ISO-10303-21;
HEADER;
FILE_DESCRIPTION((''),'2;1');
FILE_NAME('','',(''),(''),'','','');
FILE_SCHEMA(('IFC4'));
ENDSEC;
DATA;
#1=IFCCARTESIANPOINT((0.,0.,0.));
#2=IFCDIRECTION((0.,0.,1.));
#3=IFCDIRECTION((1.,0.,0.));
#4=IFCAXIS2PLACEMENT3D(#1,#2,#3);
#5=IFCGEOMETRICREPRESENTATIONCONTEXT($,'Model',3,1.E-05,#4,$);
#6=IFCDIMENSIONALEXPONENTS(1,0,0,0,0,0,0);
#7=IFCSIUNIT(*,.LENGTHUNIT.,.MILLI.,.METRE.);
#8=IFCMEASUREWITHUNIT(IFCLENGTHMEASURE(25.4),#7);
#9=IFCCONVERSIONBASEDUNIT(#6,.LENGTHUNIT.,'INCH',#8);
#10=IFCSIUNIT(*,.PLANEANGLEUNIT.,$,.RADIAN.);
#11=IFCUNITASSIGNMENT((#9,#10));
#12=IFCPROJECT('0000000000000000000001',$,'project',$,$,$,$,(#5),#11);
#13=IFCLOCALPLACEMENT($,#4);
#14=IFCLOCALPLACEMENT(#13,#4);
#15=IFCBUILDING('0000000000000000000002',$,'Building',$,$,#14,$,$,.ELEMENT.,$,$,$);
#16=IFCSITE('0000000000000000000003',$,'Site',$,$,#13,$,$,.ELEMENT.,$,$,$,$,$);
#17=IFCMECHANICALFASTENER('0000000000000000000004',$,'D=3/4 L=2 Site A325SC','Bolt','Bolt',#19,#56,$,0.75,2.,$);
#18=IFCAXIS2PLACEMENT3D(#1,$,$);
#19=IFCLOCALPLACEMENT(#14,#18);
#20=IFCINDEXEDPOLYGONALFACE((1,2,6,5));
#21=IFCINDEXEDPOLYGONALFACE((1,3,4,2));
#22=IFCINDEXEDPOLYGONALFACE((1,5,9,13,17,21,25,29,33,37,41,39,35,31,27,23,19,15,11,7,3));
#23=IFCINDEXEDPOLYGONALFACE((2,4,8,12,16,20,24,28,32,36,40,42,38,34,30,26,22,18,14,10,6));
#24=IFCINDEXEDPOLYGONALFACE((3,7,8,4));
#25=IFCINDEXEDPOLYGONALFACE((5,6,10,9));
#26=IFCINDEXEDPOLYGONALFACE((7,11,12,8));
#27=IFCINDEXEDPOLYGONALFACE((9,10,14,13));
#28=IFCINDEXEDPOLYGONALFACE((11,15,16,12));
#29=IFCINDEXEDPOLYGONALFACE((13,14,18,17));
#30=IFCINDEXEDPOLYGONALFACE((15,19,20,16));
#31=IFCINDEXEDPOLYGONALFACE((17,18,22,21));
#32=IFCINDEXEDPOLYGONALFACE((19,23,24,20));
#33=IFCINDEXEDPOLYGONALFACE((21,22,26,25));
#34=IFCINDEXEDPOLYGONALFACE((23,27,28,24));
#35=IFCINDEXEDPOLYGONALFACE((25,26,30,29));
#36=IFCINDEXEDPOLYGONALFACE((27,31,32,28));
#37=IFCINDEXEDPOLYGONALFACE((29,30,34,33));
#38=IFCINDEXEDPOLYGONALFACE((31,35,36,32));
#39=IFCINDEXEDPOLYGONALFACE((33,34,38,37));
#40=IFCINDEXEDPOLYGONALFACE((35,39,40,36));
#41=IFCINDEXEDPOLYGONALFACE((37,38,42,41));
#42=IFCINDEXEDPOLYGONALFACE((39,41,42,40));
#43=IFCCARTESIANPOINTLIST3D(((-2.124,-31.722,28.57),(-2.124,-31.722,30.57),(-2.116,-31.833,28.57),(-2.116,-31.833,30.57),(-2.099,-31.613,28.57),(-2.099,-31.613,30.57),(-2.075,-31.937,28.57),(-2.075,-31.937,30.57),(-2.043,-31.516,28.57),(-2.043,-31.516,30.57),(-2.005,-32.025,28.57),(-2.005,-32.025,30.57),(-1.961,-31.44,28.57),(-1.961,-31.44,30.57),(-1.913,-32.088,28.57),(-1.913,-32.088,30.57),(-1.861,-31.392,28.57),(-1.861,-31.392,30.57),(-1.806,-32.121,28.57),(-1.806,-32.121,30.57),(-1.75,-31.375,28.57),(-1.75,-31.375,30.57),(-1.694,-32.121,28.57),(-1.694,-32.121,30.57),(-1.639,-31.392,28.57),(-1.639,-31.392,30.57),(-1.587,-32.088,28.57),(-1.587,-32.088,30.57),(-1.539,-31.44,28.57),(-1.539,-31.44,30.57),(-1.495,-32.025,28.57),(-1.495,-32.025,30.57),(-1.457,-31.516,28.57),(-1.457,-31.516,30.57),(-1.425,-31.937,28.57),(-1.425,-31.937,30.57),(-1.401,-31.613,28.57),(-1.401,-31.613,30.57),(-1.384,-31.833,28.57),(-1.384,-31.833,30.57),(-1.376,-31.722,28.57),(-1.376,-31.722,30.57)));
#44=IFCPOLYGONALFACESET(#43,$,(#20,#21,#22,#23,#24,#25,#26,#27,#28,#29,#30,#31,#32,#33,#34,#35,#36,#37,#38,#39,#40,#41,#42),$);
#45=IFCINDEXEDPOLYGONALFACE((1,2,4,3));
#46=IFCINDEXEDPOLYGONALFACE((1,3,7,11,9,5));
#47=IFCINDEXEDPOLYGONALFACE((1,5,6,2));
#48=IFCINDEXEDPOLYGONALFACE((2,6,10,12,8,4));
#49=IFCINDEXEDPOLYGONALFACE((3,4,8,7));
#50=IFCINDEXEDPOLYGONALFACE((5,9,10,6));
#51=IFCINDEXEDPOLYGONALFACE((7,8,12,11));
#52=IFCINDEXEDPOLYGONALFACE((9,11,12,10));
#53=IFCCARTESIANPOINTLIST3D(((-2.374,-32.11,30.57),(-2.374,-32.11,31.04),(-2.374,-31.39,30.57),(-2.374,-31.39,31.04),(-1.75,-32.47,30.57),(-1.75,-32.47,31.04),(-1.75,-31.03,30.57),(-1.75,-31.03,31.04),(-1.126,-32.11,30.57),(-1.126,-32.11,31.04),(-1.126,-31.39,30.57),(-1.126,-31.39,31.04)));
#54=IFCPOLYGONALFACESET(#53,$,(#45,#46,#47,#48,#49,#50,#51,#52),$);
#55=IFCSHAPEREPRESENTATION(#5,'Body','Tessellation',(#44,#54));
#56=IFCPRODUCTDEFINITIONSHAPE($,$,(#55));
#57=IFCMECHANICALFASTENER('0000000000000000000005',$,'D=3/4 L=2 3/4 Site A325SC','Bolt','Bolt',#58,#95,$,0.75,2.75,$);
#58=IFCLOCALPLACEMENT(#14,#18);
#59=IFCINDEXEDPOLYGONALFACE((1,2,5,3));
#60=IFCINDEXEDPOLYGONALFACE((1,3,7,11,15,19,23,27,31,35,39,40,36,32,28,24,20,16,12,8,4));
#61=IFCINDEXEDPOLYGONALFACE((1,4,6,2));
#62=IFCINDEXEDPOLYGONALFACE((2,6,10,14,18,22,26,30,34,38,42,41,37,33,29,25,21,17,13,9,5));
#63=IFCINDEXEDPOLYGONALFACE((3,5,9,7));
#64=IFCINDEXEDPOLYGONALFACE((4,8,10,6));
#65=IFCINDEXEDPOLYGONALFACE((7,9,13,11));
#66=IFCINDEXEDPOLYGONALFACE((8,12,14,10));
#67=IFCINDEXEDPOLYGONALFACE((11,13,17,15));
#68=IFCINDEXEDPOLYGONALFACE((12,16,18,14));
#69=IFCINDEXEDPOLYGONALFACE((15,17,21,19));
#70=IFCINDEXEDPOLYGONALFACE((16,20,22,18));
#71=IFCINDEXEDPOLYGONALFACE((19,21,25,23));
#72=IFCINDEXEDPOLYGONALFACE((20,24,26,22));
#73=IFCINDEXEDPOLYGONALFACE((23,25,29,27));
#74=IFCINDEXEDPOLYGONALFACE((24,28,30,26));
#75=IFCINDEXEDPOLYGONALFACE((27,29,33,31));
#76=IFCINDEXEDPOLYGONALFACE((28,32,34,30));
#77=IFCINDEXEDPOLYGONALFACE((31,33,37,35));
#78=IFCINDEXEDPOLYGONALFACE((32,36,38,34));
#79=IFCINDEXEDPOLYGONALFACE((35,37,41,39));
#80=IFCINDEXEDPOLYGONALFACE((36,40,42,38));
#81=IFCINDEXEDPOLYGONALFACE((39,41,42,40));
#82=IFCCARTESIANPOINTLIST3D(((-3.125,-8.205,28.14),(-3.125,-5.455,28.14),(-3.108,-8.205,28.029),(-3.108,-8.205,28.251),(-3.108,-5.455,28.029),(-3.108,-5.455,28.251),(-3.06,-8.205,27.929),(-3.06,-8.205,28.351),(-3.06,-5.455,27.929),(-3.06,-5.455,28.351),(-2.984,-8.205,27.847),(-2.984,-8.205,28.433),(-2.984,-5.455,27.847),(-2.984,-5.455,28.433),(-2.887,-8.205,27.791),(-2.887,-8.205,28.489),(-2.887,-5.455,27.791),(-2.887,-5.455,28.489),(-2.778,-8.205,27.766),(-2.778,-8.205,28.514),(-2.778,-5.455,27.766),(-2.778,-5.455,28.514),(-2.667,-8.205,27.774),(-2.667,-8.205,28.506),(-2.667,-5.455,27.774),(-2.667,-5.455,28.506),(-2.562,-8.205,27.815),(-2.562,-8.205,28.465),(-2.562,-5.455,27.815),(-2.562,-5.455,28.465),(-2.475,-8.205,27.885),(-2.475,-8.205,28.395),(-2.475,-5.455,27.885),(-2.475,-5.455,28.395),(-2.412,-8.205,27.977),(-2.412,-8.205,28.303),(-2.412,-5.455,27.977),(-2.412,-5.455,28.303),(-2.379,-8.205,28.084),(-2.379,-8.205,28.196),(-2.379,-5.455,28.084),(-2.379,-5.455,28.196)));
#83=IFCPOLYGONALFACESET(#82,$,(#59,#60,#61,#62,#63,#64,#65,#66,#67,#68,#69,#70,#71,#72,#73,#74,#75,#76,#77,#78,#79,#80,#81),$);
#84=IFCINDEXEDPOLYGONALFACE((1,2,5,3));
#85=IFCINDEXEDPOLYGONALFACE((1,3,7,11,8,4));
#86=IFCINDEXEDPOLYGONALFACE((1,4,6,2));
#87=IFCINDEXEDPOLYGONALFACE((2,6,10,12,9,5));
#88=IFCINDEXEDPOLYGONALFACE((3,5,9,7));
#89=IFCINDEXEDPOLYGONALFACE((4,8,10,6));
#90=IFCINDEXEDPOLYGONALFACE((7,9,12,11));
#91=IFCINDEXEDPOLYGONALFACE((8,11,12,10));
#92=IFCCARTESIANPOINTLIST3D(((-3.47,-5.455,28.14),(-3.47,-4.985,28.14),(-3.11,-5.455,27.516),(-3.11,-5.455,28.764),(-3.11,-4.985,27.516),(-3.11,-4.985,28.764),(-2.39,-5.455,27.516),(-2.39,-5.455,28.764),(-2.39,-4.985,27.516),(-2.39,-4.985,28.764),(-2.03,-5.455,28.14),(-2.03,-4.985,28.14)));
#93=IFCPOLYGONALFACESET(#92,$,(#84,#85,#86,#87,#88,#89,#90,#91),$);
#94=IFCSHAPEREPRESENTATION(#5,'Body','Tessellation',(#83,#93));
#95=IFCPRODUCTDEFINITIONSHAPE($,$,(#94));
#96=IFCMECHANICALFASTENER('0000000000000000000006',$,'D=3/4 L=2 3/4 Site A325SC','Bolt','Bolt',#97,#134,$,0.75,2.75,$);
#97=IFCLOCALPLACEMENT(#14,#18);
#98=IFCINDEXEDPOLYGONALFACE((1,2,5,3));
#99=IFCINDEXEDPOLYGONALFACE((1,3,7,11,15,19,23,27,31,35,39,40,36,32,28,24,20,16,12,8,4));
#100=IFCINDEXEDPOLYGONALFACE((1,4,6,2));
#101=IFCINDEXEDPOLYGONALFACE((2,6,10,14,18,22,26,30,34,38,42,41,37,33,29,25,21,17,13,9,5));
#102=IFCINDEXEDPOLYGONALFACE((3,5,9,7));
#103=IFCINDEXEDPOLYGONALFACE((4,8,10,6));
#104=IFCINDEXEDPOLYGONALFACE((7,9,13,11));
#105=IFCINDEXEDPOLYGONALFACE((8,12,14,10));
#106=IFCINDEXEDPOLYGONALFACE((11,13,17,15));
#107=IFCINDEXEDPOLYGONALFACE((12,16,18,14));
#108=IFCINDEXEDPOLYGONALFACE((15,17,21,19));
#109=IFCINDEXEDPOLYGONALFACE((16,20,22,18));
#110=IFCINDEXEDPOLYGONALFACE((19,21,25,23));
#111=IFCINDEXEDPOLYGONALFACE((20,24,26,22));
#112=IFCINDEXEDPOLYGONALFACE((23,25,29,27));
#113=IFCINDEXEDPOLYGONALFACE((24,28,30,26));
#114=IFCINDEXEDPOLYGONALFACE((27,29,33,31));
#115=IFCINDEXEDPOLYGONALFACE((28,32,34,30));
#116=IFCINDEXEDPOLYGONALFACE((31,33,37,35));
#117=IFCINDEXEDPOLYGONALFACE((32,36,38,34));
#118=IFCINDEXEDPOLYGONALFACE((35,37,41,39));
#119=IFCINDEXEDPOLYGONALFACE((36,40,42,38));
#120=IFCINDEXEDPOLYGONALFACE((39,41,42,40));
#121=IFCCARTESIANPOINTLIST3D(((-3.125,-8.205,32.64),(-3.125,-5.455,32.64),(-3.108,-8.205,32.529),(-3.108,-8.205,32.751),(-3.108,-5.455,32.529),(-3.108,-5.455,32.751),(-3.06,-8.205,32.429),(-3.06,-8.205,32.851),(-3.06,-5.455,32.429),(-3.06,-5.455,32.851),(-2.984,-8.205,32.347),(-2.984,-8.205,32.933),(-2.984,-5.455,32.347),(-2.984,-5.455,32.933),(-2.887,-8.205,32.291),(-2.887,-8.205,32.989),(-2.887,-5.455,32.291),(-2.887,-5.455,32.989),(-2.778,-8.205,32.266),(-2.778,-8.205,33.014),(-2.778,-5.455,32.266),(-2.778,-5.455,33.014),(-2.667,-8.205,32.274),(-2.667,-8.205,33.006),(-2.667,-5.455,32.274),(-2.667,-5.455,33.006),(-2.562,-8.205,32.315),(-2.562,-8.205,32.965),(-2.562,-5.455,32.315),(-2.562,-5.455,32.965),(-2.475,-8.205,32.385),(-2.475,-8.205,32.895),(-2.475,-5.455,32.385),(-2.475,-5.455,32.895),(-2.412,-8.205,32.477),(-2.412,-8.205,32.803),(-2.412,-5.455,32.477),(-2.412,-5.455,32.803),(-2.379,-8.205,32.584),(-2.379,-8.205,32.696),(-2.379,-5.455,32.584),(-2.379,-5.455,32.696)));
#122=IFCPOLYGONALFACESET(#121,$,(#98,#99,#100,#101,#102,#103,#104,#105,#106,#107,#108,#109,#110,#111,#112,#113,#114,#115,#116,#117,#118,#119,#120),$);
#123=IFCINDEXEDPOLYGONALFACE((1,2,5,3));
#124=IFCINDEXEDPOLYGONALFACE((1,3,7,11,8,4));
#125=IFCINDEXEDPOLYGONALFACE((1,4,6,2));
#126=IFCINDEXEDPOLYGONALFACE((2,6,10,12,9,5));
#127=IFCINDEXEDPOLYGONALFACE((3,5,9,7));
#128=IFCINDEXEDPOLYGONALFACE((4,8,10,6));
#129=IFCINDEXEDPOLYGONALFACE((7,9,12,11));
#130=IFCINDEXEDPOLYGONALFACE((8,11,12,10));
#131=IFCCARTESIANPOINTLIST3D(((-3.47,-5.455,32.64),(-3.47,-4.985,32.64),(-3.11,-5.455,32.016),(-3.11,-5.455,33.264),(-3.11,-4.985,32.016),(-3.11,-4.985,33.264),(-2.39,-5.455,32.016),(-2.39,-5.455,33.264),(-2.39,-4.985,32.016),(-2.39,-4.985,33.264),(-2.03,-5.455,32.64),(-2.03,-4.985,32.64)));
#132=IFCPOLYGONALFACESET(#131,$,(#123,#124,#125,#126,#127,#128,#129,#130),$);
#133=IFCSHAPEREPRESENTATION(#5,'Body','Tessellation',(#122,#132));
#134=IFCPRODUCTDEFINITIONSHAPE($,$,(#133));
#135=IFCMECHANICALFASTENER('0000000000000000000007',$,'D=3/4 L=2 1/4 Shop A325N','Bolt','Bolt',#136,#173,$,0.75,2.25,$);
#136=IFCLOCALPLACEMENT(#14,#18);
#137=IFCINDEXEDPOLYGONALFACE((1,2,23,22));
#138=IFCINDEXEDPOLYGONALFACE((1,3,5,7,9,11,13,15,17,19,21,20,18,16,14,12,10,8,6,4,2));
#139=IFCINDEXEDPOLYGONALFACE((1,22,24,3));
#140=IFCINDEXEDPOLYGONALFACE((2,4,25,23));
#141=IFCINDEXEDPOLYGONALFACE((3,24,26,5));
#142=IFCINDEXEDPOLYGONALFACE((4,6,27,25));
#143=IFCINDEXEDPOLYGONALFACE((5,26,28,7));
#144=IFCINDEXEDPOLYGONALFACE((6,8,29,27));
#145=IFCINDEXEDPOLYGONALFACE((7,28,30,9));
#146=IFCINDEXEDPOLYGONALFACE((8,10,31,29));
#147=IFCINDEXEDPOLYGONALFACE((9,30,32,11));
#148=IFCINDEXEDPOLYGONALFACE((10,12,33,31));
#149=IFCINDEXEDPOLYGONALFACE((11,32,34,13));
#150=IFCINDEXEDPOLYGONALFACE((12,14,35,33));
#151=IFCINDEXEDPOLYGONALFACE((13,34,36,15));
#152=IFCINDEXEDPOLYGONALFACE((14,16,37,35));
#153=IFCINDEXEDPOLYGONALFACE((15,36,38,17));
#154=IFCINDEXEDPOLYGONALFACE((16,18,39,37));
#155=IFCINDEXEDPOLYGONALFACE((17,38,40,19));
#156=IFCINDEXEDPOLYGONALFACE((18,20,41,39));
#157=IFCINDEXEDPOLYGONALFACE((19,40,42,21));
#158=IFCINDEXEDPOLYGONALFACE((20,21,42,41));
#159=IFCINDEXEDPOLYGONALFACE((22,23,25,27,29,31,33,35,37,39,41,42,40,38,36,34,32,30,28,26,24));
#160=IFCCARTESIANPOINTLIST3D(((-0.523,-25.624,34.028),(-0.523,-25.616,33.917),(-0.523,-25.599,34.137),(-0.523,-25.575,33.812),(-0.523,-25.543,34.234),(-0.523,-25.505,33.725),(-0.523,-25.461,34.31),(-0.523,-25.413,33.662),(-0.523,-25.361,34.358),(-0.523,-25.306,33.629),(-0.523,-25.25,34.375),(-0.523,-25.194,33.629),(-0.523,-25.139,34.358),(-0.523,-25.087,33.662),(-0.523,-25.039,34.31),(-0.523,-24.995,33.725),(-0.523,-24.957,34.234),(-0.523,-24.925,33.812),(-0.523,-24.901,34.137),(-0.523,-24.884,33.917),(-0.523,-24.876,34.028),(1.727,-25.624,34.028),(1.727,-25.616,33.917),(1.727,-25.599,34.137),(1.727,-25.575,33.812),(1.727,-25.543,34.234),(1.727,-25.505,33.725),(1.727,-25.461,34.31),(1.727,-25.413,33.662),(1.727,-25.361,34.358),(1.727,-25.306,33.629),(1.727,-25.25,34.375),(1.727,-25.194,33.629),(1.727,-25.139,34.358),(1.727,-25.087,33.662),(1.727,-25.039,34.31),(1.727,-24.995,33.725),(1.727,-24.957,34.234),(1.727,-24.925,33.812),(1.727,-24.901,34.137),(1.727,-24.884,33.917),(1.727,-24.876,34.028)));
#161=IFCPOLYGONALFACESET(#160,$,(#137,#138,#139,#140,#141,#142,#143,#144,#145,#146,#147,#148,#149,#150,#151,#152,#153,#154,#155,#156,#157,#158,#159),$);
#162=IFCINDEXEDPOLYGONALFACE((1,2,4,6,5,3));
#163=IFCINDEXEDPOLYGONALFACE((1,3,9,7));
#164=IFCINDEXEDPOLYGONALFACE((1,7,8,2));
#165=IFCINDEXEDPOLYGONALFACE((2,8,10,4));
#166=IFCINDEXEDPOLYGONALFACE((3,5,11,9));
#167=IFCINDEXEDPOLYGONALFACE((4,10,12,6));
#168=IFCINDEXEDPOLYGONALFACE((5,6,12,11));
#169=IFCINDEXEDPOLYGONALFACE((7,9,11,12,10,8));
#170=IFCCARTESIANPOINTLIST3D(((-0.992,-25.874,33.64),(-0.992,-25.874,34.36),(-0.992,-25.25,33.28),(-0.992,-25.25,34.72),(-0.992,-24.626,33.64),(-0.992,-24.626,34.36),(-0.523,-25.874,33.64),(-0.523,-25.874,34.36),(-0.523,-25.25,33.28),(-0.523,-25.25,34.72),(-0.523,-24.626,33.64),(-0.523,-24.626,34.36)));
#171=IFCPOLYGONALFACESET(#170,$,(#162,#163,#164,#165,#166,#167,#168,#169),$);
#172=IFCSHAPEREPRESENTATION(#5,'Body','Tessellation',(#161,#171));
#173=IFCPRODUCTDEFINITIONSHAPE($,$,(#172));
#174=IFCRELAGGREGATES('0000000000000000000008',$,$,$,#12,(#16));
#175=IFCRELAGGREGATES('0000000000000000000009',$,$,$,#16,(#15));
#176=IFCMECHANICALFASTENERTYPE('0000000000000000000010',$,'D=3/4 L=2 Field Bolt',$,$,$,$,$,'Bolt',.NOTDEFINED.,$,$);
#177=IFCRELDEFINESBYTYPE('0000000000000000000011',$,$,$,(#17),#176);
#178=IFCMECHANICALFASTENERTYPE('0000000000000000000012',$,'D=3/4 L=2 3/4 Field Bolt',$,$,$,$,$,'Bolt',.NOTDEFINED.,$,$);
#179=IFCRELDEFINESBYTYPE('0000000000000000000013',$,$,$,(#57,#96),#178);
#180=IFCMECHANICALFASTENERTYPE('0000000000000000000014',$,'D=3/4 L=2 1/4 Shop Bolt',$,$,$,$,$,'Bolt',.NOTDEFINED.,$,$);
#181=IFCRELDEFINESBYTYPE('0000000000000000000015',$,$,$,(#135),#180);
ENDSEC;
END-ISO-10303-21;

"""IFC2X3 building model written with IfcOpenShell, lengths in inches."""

from ifc_helpers import new_model, entity, si_unit, converted_unit, frame, origin_with_axes, origin_2d_with_axis, place, context, project, spatial, polyline, circle, outline, extrude, source, transform, mapped, type_object, type_shapes, element, save


model = new_model("IFC2X3")

# Units and contexts
model_context = context("Model", 3, precision=1e-05, world=origin_with_axes())
ifc_project = project(units=[converted_unit("LENGTHUNIT", "INCH", entity("IfcLengthMeasure", 25.4), si_unit("LENGTHUNIT", "METRE", prefix="MILLI"), dimensions=[1, 0, 0, 0, 0, 0, 0]), si_unit("PLANEANGLEUNIT", "RADIAN")], contexts=[model_context])

# Site, building
site_placement = place(None, origin_with_axes())
site = spatial("IfcSite", under=ifc_project, at=site_placement, Name="Site", CompositionType="ELEMENT")
building_placement = place(site_placement, origin_with_axes())
building = spatial("IfcBuilding", under=site, at=building_placement, Name="Building", CompositionType="ELEMENT")

# Mechanical fasteners
placement_1 = place(building_placement, frame((0.0, 0.0, 46.0), z_axis=(0.0, 0.0, 1.0), x_axis=(0.0, -1.0, 0.0)))
mechanical_fastener_type_1 = type_object("IfcMechanicalFastenerType", Name="D=3/4 L=2 Field Bolt", ElementType="Bolt")
shared_shape_1 = source(origin_with_axes(), model_context, "Body", "SweptSolid", [
    extrude(circle(Radius=0.375, at=origin_2d_with_axis()), frame((0.0, 0.0, 0.0), z_axis=(1.0, 0.0, 0.0), x_axis=(0.0, 1.0, 0.0)), (0.0, 0.0, 1.0), 2.0),
    extrude(outline(polyline([(-0.72, 0.0), (-0.36, 0.624), (0.36, 0.624), (0.72, 0.0), (0.36, -0.624), (-0.36, -0.624), (-0.72, 0.0)])), frame((0.0, 0.0, 0.0), z_axis=(1.0, 0.0, 0.0), x_axis=(0.0, 1.0, 0.0)), (0.0, 0.0, -1.0), 0.47),
])
type_shapes(mechanical_fastener_type_1, [shared_shape_1])
placement_2 = place(placement_1, frame((28.75, -1.75, -15.43), z_axis=(0.0, 1.0, 0.0), x_axis=(0.0, 0.0, -1.0)))
for number, where, z_axis, x_axis, name in (
    (1, (0.0, -3.0, 0.0), (0.0, 0.0, 1.0), (1.0, 0.0, 0.0), "D=3/4 L=2 Site A325SC"),
):
    element("IfcMechanicalFastener", number, at=place(placement_2, frame(where, z_axis=z_axis, x_axis=x_axis)), type_object=mechanical_fastener_type_1, Name=name, Description="Bolt", ObjectType="Bolt", NominalDiameter=0.75, NominalLength=2.0, context=model_context, shape_type="MappedRepresentation", body=[
        mapped(shared_shape_1, transform((0.0, 0.0, 0.0), scale=1.0)),
    ])
mechanical_fastener_type_2 = type_object("IfcMechanicalFastenerType", Name="D=3/4 L=2 3/4 Field Bolt", ElementType="Bolt")
shared_shape_2 = source(origin_with_axes(), model_context, "Body", "SweptSolid", [
    extrude(circle(Radius=0.375, at=origin_2d_with_axis()), frame((0.0, 0.0, 0.0), z_axis=(1.0, 0.0, 0.0), x_axis=(0.0, 1.0, 0.0)), (0.0, 0.0, 1.0), 2.75),
    extrude(outline(polyline([(-0.72, 0.0), (-0.36, 0.624), (0.36, 0.624), (0.72, 0.0), (0.36, -0.624), (-0.36, -0.624), (-0.72, 0.0)])), frame((0.0, 0.0, 0.0), z_axis=(1.0, 0.0, 0.0), x_axis=(0.0, 1.0, 0.0)), (0.0, 0.0, -1.0), 0.47),
])
type_shapes(mechanical_fastener_type_2, [shared_shape_2])
placement_3 = place(placement_1, frame((5.455, -2.75, 2.0), z_axis=(0.0, 0.0, -1.0), x_axis=(1.0, 0.0, 0.0)))
for number, where, z_axis, x_axis, name in (
    (2, (0.0, 0.0, 19.86), (0.0, 0.0, 1.0), (1.0, 0.0, 0.0), "D=3/4 L=2 3/4 Site A325SC"),
    (3, (0.0, 0.0, 15.36), (0.0, 0.0, 1.0), (1.0, 0.0, 0.0), "D=3/4 L=2 3/4 Site A325SC"),
):
    element("IfcMechanicalFastener", number, at=place(placement_3, frame(where, z_axis=z_axis, x_axis=x_axis)), type_object=mechanical_fastener_type_2, Name=name, Description="Bolt", ObjectType="Bolt", NominalDiameter=0.75, NominalLength=2.75, context=model_context, shape_type="MappedRepresentation", body=[
        mapped(shared_shape_2, transform((0.0, 0.0, 0.0), scale=1.0)),
    ])
mechanical_fastener_type_3 = type_object("IfcMechanicalFastenerType", Name="D=3/4 L=2 1/4 Shop Bolt", ElementType="Bolt")
shared_shape_3 = source(origin_with_axes(), model_context, "Body", "SweptSolid", [
    extrude(circle(Radius=0.375, at=origin_2d_with_axis()), frame((0.0, 0.0, 0.0), z_axis=(1.0, 0.0, 0.0), x_axis=(0.0, 1.0, 0.0)), (0.0, 0.0, 1.0), 2.25),
    extrude(outline(polyline([(-0.72, 0.0), (-0.36, 0.624), (0.36, 0.624), (0.72, 0.0), (0.36, -0.624), (-0.36, -0.624), (-0.72, 0.0)])), frame((0.0, 0.0, 0.0), z_axis=(1.0, 0.0, 0.0), x_axis=(0.0, 1.0, 0.0)), (0.0, 0.0, -1.0), 0.47),
])
type_shapes(mechanical_fastener_type_3, [shared_shape_3])
placement_4 = place(placement_1, frame((25.25, -0.523, -3.0), z_axis=(1.0, 0.0, 0.0), x_axis=(0.0, 1.0, 0.0)))
for number, where, z_axis, x_axis, name in (
    (4, (0.0, -9.0, 0.0), (0.0, 0.0, 1.0), (1.0, 0.0, 0.0), "D=3/4 L=2 1/4 Shop A325N"),
):
    element("IfcMechanicalFastener", number, at=place(placement_4, frame(where, z_axis=z_axis, x_axis=x_axis)), type_object=mechanical_fastener_type_3, Name=name, Description="Bolt", ObjectType="Bolt", NominalDiameter=0.75, NominalLength=2.25, context=model_context, shape_type="MappedRepresentation", body=[
        mapped(shared_shape_3, transform((0.0, 0.0, 0.0), scale=1.0)),
    ])

save(model, "model.ifc")
